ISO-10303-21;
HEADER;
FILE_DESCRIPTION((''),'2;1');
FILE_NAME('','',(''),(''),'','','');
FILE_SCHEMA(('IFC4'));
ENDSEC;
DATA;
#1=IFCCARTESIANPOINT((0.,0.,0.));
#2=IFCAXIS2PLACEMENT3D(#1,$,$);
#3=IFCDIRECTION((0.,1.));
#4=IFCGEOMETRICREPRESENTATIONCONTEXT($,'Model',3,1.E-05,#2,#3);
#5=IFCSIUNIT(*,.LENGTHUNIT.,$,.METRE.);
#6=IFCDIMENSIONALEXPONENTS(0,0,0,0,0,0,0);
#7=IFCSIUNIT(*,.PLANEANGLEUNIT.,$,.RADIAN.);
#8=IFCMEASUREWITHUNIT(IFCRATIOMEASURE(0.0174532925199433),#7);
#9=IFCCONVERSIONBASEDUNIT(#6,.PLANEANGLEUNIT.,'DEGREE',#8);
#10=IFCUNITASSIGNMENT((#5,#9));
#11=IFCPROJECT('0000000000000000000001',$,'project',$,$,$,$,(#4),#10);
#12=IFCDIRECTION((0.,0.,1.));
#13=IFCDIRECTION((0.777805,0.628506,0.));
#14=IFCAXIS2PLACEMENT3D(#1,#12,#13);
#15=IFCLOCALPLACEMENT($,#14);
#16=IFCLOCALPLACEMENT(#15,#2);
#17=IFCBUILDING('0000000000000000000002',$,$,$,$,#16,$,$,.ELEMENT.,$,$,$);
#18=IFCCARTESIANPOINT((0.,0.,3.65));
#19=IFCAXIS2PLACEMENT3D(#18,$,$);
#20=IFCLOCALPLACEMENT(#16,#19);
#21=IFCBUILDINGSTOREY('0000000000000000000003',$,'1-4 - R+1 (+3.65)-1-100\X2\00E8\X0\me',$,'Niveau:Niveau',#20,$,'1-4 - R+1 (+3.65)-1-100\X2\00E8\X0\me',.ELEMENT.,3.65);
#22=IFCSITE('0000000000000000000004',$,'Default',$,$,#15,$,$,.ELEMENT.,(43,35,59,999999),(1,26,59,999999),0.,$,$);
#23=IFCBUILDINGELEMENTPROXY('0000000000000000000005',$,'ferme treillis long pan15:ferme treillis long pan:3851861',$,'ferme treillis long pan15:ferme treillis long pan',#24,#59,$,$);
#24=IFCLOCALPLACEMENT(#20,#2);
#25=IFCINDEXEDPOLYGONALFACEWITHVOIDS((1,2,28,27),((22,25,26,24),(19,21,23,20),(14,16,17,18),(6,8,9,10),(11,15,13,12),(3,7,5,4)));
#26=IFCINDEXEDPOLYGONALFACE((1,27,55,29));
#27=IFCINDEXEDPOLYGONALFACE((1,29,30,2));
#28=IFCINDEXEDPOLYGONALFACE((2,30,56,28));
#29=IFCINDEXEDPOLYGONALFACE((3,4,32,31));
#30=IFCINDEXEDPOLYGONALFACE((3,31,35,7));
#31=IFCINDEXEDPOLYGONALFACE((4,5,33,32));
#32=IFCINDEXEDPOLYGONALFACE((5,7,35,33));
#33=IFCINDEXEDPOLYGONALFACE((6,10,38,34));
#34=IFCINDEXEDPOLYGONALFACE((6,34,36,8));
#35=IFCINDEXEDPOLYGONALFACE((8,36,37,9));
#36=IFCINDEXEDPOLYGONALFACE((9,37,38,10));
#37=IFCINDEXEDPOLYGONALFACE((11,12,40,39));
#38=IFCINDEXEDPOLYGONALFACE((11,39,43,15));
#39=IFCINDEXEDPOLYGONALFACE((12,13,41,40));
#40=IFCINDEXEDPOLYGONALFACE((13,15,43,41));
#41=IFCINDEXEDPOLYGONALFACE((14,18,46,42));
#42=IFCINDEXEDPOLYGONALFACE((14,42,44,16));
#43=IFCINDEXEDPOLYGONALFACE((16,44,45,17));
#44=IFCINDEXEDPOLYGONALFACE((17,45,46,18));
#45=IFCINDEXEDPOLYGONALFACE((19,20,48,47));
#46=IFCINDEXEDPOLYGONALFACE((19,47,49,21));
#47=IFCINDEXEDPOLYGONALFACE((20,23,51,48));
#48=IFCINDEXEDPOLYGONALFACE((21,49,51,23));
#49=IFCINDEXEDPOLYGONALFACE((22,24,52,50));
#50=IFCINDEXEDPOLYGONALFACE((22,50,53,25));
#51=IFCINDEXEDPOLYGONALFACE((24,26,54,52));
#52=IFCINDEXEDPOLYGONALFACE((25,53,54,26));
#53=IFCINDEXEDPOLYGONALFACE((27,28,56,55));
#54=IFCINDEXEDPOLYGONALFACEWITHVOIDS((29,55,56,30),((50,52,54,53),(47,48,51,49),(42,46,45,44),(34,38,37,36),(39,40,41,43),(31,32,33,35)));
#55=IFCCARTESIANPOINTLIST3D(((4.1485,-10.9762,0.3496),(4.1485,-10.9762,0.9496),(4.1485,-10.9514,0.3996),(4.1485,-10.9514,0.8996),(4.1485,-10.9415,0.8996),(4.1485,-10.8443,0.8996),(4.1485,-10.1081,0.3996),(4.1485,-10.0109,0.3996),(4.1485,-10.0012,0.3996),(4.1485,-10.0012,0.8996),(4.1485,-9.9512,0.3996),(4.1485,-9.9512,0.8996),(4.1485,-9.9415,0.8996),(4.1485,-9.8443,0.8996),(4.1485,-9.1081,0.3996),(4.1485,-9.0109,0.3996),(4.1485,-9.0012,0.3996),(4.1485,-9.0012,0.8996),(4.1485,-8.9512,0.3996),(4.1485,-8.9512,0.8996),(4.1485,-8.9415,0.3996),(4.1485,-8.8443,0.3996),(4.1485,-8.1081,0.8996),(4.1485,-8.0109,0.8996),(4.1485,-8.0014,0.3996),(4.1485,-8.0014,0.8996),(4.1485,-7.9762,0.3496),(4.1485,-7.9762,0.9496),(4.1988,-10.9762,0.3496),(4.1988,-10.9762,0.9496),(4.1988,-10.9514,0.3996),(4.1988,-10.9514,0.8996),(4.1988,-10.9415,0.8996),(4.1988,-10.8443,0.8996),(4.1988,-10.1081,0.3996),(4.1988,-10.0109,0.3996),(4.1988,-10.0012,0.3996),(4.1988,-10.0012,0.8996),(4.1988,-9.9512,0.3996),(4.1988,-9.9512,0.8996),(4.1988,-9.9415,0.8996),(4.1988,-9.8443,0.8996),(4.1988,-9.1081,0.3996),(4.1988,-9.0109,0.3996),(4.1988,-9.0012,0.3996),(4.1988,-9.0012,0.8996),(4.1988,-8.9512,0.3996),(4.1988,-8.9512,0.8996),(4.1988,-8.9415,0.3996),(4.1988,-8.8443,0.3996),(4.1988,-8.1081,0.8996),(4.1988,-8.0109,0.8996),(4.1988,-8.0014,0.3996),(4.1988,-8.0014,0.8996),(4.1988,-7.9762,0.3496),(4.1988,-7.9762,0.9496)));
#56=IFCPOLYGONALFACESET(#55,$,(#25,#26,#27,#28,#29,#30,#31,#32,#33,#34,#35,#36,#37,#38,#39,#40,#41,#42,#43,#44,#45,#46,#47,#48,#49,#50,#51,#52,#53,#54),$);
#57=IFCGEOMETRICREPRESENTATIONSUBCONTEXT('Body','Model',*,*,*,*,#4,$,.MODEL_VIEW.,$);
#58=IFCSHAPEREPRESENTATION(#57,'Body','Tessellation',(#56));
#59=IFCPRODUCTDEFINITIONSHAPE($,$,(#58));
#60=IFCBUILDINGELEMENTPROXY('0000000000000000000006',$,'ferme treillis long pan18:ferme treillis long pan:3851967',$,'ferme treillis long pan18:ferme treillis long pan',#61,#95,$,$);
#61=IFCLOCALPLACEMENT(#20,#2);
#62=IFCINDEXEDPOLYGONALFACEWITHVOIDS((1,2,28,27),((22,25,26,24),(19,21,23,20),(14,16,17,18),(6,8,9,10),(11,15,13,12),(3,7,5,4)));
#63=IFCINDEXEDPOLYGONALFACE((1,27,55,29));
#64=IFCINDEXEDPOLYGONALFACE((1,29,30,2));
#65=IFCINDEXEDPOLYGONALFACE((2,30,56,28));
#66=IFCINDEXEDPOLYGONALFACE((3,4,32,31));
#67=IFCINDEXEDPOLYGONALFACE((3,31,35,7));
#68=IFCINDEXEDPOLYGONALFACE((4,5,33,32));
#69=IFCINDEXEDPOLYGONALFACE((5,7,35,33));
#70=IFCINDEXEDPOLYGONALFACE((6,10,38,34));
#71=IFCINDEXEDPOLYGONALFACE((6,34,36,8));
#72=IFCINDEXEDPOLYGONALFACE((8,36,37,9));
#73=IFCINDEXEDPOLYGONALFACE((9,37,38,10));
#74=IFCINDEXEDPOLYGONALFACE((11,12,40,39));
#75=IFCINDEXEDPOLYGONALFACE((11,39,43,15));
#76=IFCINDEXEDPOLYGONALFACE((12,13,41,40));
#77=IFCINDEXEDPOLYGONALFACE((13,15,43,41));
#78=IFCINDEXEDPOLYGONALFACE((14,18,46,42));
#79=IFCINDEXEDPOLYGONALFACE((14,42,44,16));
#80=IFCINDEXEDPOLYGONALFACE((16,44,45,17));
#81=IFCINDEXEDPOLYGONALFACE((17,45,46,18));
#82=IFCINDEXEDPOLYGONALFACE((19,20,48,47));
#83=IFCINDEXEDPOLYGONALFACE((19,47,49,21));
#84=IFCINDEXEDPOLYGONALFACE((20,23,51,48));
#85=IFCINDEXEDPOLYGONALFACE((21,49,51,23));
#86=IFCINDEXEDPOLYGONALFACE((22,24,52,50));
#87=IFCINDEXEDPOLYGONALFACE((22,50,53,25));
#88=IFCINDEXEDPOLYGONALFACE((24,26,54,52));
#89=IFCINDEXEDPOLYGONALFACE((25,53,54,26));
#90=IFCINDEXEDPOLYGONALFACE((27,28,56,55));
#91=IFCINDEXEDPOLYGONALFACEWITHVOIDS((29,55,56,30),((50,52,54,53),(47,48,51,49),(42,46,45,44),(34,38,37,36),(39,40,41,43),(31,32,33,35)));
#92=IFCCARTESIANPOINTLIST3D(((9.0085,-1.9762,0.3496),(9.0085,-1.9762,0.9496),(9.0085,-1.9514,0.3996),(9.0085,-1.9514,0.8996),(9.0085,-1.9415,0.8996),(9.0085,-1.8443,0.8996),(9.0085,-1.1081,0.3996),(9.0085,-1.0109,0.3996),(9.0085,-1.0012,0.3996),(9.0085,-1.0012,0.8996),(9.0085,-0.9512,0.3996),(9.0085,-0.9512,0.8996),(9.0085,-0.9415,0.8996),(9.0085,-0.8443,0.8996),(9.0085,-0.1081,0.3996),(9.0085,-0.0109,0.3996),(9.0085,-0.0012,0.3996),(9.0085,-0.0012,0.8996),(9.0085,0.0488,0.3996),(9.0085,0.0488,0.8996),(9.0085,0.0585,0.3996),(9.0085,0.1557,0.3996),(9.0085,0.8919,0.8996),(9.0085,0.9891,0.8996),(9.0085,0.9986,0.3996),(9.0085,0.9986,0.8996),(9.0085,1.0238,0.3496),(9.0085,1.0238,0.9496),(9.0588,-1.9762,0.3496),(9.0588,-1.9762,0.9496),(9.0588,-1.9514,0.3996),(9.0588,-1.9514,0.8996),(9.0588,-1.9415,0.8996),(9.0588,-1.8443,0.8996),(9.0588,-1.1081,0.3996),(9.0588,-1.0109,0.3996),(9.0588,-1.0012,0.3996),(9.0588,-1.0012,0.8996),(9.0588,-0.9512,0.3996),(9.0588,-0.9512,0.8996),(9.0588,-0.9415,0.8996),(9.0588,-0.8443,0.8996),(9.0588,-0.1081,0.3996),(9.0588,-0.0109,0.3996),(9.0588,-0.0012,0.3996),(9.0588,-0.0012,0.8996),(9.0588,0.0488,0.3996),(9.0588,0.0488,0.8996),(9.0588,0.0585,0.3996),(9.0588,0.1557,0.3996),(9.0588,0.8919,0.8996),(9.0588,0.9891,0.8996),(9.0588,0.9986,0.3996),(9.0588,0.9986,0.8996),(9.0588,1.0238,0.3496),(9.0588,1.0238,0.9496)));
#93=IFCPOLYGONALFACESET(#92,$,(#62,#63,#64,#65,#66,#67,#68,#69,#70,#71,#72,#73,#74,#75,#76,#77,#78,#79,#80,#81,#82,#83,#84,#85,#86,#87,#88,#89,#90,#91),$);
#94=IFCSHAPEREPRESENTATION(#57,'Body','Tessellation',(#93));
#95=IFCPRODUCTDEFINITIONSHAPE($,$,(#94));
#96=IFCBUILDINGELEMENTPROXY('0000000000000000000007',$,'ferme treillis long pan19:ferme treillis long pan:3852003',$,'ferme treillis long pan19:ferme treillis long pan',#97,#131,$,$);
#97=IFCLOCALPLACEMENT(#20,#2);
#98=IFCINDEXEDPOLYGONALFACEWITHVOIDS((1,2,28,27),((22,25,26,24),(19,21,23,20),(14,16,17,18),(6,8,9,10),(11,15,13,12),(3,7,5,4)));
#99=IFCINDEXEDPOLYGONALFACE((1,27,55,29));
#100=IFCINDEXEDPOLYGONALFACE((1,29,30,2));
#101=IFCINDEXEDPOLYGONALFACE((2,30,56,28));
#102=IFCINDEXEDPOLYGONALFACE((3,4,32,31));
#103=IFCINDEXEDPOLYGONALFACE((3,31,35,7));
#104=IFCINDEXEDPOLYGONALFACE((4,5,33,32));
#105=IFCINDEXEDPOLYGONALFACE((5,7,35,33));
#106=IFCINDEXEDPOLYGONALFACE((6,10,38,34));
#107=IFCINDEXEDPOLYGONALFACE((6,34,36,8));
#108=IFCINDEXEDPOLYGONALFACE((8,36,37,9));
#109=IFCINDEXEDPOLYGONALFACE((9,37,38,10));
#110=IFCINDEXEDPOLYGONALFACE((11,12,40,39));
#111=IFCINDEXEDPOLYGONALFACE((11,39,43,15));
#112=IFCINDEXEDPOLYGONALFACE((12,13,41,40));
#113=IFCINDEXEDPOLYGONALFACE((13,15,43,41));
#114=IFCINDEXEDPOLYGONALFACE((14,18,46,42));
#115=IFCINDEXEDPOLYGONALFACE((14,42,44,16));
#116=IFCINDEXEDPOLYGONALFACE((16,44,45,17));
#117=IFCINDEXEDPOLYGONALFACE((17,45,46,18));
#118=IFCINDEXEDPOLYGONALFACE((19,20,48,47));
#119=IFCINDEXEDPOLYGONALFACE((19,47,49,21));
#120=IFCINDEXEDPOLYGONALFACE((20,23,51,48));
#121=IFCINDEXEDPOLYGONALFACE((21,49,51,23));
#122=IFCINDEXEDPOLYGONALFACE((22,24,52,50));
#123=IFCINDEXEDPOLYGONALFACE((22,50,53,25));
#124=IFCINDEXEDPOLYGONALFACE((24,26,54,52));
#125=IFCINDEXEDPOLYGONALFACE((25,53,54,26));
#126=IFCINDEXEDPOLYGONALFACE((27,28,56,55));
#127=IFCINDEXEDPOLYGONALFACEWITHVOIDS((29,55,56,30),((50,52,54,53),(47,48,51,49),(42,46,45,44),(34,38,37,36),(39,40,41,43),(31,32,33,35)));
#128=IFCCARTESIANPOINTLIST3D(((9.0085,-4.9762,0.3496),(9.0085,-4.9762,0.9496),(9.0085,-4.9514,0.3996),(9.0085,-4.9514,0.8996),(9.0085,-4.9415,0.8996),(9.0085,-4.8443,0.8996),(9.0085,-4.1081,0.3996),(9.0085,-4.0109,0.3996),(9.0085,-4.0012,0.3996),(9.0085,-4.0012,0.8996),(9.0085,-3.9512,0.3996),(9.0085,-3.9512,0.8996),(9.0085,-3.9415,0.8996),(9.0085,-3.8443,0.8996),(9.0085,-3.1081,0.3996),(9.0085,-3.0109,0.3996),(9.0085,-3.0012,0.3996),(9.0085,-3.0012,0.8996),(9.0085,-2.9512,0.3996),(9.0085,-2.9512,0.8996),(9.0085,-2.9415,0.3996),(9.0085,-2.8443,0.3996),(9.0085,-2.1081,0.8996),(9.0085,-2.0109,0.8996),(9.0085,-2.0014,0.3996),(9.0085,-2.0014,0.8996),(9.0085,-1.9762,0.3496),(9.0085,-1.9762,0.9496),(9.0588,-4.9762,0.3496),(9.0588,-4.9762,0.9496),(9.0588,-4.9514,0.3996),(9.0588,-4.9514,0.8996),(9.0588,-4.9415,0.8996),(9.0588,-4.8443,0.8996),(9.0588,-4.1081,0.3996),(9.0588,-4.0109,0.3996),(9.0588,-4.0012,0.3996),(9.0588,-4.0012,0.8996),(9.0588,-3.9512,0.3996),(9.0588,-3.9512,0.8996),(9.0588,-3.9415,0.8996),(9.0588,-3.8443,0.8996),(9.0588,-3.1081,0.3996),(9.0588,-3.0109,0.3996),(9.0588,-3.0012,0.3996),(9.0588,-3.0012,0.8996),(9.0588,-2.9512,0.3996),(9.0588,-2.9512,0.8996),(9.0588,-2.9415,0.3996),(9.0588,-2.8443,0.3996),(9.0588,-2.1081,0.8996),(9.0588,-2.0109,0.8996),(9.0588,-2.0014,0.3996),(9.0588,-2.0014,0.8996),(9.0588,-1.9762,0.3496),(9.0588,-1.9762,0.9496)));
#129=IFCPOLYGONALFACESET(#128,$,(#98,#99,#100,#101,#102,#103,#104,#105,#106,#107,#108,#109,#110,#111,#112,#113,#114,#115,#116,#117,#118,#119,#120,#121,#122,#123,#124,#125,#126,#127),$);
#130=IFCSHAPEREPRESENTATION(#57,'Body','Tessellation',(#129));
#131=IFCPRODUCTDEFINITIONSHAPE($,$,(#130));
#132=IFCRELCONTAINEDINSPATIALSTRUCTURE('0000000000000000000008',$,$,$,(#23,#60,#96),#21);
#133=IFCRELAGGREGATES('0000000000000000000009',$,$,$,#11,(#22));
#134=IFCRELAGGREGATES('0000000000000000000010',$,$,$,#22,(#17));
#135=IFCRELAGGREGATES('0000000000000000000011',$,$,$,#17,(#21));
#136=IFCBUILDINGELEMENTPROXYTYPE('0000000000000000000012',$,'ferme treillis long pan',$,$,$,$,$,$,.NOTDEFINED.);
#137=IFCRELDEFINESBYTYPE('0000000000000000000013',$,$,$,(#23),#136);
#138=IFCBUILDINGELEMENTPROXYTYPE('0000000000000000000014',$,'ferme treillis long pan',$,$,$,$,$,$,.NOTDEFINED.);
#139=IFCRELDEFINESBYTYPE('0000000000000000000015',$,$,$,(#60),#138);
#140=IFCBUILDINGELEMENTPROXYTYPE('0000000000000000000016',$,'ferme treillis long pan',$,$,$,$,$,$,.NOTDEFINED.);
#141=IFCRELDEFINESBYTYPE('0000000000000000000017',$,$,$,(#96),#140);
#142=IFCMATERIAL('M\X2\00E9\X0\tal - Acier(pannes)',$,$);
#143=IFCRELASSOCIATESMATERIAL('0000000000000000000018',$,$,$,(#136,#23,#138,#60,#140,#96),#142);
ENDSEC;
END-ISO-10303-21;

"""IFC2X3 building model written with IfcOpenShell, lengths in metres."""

from ifc_helpers import new_model, entity, si_unit, converted_unit, direction, frame, origin, place, context, subcontext, project, spatial, polyline, outline, extrude, source, transform, mapped, material, type_object, type_shapes, element, save


model = new_model("IFC2X3")

# Units and contexts
model_context = context("Model", 3, precision=1e-05, world=origin(), true_north=direction((0.0, 1.0)))
body_context = subcontext(model_context, "Body", "Model", "MODEL_VIEW")
ifc_project = project(units=[si_unit("LENGTHUNIT", "METRE"), converted_unit("PLANEANGLEUNIT", "DEGREE", entity("IfcRatioMeasure", 0.0174532925199433), si_unit("PLANEANGLEUNIT", "RADIAN"), dimensions=[0, 0, 0, 0, 0, 0, 0])], contexts=[model_context])

# Site, building, storey
site_placement = place(None, frame((0.0, 0.0, 0.0), z_axis=(0.0, 0.0, 1.0), x_axis=(0.777805, 0.628506, 0.0)))
site = spatial("IfcSite", under=ifc_project, at=site_placement, Name="Default", CompositionType="ELEMENT", RefLatitude=(43, 35, 59, 999999), RefLongitude=(1, 26, 59, 999999), RefElevation=0.0)
building_placement = place(site_placement, origin())
building = spatial("IfcBuilding", under=site, at=building_placement, CompositionType="ELEMENT")
storey_placement = place(building_placement, frame((0.0, 0.0, 3.65)))
storey = spatial("IfcBuildingStorey", under=building, at=storey_placement, Name="1-4 - R+1 (+3.65)-1-100ème", ObjectType="Niveau:Niveau", LongName="1-4 - R+1 (+3.65)-1-100ème", CompositionType="ELEMENT", Elevation=3.65)

# Building element proxies
ifc_material_1 = material(Name="Métal - Acier(pannes)")
building_element_proxy_type_1 = type_object("IfcBuildingElementProxyType", Name="ferme treillis long pan", PredefinedType="NOTDEFINED", material=ifc_material_1)
shared_shape_1 = source(origin(), body_context, "Body", "SweptSolid", [
    extrude(outline(polyline([(-0.3, -1.5), (0.3, -1.5), (0.3, 1.5), (-0.3, 1.5), (-0.3, -1.5)]), holes=[polyline([(-0.25, 1.4653), (-0.25, 1.4748), (0.25, 1.4748), (0.25, 0.6319), (-0.25, 1.4653)]), polyline([(0.25, -0.6319), (0.25, -1.4752), (-0.25, -1.4752), (-0.25, -1.4653), (0.25, -0.6319)]), polyline([(0.25, 0.5347), (0.25, 0.525), (-0.25, 0.525), (-0.25, 1.3681), (0.25, 0.5347)]), polyline([(0.25, 0.475), (0.25, 0.4653), (-0.25, -0.3681), (-0.25, 0.475), (0.25, 0.475)]), polyline([(0.25, -0.475), (-0.25, -0.475), (-0.25, -0.4653), (0.25, 0.3681), (0.25, -0.475)]), polyline([(0.25, -0.525), (0.25, -0.5347), (-0.25, -1.3681), (-0.25, -0.525), (0.25, -0.525)])]), frame((4.1485, -9.4762, 4.2996), z_axis=(1.0, 0.0, 0.0), x_axis=(0.0, 0.0, -1.0)), (0.0, 0.0, 1.0), 0.0503),
])
type_shapes(building_element_proxy_type_1, [shared_shape_1])
proxy_1_placement = place(storey_placement, frame((0.0, 0.0, -3.65)))
element("IfcBuildingElementProxy", 1, at=proxy_1_placement, inside=storey, type_object=building_element_proxy_type_1, material=ifc_material_1, Name="ferme treillis long pan15:ferme treillis long pan:3851861", ObjectType="ferme treillis long pan15:ferme treillis long pan", context=body_context, shape_type="MappedRepresentation", body=[
    mapped(shared_shape_1, transform((0.0, 0.0, 0.0), scale=1.0)),
])
building_element_proxy_type_2 = type_object("IfcBuildingElementProxyType", Name="ferme treillis long pan", PredefinedType="NOTDEFINED", material=ifc_material_1)
shared_shape_2 = source(origin(), body_context, "Body", "SweptSolid", [
    extrude(outline(polyline([(-0.3, -1.5), (0.3, -1.5), (0.3, 1.5), (-0.3, 1.5), (-0.3, -1.5)]), holes=[polyline([(-0.25, 1.4653), (-0.25, 1.4748), (0.25, 1.4748), (0.25, 0.6319), (-0.25, 1.4653)]), polyline([(0.25, -0.6319), (0.25, -1.4752), (-0.25, -1.4752), (-0.25, -1.4653), (0.25, -0.6319)]), polyline([(0.25, 0.5347), (0.25, 0.525), (-0.25, 0.525), (-0.25, 1.3681), (0.25, 0.5347)]), polyline([(0.25, 0.475), (0.25, 0.4653), (-0.25, -0.3681), (-0.25, 0.475), (0.25, 0.475)]), polyline([(0.25, -0.475), (-0.25, -0.475), (-0.25, -0.4653), (0.25, 0.3681), (0.25, -0.475)]), polyline([(0.25, -0.525), (0.25, -0.5347), (-0.25, -1.3681), (-0.25, -0.525), (0.25, -0.525)])]), frame((9.0085, -0.4762, 4.2996), z_axis=(1.0, 0.0, 0.0), x_axis=(0.0, 0.0, -1.0)), (0.0, 0.0, 1.0), 0.0503),
])
type_shapes(building_element_proxy_type_2, [shared_shape_2])
proxy_2_placement = place(storey_placement, frame((0.0, 0.0, -3.65)))
element("IfcBuildingElementProxy", 2, at=proxy_2_placement, inside=storey, type_object=building_element_proxy_type_2, material=ifc_material_1, Name="ferme treillis long pan18:ferme treillis long pan:3851967", ObjectType="ferme treillis long pan18:ferme treillis long pan", context=body_context, shape_type="MappedRepresentation", body=[
    mapped(shared_shape_2, transform((0.0, 0.0, 0.0), scale=1.0)),
])
building_element_proxy_type_3 = type_object("IfcBuildingElementProxyType", Name="ferme treillis long pan", PredefinedType="NOTDEFINED", material=ifc_material_1)
shared_shape_3 = source(origin(), body_context, "Body", "SweptSolid", [
    extrude(outline(polyline([(-0.3, -1.5), (0.3, -1.5), (0.3, 1.5), (-0.3, 1.5), (-0.3, -1.5)]), holes=[polyline([(-0.25, 1.4653), (-0.25, 1.4748), (0.25, 1.4748), (0.25, 0.6319), (-0.25, 1.4653)]), polyline([(0.25, -0.6319), (0.25, -1.4752), (-0.25, -1.4752), (-0.25, -1.4653), (0.25, -0.6319)]), polyline([(0.25, 0.5347), (0.25, 0.525), (-0.25, 0.525), (-0.25, 1.3681), (0.25, 0.5347)]), polyline([(0.25, 0.475), (0.25, 0.4653), (-0.25, -0.3681), (-0.25, 0.475), (0.25, 0.475)]), polyline([(0.25, -0.475), (-0.25, -0.475), (-0.25, -0.4653), (0.25, 0.3681), (0.25, -0.475)]), polyline([(0.25, -0.525), (0.25, -0.5347), (-0.25, -1.3681), (-0.25, -0.525), (0.25, -0.525)])]), frame((9.0085, -3.4762, 4.2996), z_axis=(1.0, 0.0, 0.0), x_axis=(0.0, 0.0, -1.0)), (0.0, 0.0, 1.0), 0.0503),
])
type_shapes(building_element_proxy_type_3, [shared_shape_3])
proxy_3_placement = place(storey_placement, frame((0.0, 0.0, -3.65)))
element("IfcBuildingElementProxy", 3, at=proxy_3_placement, inside=storey, type_object=building_element_proxy_type_3, material=ifc_material_1, Name="ferme treillis long pan19:ferme treillis long pan:3852003", ObjectType="ferme treillis long pan19:ferme treillis long pan", context=body_context, shape_type="MappedRepresentation", body=[
    mapped(shared_shape_3, transform((0.0, 0.0, 0.0), scale=1.0)),
])

save(model, "model.ifc")
